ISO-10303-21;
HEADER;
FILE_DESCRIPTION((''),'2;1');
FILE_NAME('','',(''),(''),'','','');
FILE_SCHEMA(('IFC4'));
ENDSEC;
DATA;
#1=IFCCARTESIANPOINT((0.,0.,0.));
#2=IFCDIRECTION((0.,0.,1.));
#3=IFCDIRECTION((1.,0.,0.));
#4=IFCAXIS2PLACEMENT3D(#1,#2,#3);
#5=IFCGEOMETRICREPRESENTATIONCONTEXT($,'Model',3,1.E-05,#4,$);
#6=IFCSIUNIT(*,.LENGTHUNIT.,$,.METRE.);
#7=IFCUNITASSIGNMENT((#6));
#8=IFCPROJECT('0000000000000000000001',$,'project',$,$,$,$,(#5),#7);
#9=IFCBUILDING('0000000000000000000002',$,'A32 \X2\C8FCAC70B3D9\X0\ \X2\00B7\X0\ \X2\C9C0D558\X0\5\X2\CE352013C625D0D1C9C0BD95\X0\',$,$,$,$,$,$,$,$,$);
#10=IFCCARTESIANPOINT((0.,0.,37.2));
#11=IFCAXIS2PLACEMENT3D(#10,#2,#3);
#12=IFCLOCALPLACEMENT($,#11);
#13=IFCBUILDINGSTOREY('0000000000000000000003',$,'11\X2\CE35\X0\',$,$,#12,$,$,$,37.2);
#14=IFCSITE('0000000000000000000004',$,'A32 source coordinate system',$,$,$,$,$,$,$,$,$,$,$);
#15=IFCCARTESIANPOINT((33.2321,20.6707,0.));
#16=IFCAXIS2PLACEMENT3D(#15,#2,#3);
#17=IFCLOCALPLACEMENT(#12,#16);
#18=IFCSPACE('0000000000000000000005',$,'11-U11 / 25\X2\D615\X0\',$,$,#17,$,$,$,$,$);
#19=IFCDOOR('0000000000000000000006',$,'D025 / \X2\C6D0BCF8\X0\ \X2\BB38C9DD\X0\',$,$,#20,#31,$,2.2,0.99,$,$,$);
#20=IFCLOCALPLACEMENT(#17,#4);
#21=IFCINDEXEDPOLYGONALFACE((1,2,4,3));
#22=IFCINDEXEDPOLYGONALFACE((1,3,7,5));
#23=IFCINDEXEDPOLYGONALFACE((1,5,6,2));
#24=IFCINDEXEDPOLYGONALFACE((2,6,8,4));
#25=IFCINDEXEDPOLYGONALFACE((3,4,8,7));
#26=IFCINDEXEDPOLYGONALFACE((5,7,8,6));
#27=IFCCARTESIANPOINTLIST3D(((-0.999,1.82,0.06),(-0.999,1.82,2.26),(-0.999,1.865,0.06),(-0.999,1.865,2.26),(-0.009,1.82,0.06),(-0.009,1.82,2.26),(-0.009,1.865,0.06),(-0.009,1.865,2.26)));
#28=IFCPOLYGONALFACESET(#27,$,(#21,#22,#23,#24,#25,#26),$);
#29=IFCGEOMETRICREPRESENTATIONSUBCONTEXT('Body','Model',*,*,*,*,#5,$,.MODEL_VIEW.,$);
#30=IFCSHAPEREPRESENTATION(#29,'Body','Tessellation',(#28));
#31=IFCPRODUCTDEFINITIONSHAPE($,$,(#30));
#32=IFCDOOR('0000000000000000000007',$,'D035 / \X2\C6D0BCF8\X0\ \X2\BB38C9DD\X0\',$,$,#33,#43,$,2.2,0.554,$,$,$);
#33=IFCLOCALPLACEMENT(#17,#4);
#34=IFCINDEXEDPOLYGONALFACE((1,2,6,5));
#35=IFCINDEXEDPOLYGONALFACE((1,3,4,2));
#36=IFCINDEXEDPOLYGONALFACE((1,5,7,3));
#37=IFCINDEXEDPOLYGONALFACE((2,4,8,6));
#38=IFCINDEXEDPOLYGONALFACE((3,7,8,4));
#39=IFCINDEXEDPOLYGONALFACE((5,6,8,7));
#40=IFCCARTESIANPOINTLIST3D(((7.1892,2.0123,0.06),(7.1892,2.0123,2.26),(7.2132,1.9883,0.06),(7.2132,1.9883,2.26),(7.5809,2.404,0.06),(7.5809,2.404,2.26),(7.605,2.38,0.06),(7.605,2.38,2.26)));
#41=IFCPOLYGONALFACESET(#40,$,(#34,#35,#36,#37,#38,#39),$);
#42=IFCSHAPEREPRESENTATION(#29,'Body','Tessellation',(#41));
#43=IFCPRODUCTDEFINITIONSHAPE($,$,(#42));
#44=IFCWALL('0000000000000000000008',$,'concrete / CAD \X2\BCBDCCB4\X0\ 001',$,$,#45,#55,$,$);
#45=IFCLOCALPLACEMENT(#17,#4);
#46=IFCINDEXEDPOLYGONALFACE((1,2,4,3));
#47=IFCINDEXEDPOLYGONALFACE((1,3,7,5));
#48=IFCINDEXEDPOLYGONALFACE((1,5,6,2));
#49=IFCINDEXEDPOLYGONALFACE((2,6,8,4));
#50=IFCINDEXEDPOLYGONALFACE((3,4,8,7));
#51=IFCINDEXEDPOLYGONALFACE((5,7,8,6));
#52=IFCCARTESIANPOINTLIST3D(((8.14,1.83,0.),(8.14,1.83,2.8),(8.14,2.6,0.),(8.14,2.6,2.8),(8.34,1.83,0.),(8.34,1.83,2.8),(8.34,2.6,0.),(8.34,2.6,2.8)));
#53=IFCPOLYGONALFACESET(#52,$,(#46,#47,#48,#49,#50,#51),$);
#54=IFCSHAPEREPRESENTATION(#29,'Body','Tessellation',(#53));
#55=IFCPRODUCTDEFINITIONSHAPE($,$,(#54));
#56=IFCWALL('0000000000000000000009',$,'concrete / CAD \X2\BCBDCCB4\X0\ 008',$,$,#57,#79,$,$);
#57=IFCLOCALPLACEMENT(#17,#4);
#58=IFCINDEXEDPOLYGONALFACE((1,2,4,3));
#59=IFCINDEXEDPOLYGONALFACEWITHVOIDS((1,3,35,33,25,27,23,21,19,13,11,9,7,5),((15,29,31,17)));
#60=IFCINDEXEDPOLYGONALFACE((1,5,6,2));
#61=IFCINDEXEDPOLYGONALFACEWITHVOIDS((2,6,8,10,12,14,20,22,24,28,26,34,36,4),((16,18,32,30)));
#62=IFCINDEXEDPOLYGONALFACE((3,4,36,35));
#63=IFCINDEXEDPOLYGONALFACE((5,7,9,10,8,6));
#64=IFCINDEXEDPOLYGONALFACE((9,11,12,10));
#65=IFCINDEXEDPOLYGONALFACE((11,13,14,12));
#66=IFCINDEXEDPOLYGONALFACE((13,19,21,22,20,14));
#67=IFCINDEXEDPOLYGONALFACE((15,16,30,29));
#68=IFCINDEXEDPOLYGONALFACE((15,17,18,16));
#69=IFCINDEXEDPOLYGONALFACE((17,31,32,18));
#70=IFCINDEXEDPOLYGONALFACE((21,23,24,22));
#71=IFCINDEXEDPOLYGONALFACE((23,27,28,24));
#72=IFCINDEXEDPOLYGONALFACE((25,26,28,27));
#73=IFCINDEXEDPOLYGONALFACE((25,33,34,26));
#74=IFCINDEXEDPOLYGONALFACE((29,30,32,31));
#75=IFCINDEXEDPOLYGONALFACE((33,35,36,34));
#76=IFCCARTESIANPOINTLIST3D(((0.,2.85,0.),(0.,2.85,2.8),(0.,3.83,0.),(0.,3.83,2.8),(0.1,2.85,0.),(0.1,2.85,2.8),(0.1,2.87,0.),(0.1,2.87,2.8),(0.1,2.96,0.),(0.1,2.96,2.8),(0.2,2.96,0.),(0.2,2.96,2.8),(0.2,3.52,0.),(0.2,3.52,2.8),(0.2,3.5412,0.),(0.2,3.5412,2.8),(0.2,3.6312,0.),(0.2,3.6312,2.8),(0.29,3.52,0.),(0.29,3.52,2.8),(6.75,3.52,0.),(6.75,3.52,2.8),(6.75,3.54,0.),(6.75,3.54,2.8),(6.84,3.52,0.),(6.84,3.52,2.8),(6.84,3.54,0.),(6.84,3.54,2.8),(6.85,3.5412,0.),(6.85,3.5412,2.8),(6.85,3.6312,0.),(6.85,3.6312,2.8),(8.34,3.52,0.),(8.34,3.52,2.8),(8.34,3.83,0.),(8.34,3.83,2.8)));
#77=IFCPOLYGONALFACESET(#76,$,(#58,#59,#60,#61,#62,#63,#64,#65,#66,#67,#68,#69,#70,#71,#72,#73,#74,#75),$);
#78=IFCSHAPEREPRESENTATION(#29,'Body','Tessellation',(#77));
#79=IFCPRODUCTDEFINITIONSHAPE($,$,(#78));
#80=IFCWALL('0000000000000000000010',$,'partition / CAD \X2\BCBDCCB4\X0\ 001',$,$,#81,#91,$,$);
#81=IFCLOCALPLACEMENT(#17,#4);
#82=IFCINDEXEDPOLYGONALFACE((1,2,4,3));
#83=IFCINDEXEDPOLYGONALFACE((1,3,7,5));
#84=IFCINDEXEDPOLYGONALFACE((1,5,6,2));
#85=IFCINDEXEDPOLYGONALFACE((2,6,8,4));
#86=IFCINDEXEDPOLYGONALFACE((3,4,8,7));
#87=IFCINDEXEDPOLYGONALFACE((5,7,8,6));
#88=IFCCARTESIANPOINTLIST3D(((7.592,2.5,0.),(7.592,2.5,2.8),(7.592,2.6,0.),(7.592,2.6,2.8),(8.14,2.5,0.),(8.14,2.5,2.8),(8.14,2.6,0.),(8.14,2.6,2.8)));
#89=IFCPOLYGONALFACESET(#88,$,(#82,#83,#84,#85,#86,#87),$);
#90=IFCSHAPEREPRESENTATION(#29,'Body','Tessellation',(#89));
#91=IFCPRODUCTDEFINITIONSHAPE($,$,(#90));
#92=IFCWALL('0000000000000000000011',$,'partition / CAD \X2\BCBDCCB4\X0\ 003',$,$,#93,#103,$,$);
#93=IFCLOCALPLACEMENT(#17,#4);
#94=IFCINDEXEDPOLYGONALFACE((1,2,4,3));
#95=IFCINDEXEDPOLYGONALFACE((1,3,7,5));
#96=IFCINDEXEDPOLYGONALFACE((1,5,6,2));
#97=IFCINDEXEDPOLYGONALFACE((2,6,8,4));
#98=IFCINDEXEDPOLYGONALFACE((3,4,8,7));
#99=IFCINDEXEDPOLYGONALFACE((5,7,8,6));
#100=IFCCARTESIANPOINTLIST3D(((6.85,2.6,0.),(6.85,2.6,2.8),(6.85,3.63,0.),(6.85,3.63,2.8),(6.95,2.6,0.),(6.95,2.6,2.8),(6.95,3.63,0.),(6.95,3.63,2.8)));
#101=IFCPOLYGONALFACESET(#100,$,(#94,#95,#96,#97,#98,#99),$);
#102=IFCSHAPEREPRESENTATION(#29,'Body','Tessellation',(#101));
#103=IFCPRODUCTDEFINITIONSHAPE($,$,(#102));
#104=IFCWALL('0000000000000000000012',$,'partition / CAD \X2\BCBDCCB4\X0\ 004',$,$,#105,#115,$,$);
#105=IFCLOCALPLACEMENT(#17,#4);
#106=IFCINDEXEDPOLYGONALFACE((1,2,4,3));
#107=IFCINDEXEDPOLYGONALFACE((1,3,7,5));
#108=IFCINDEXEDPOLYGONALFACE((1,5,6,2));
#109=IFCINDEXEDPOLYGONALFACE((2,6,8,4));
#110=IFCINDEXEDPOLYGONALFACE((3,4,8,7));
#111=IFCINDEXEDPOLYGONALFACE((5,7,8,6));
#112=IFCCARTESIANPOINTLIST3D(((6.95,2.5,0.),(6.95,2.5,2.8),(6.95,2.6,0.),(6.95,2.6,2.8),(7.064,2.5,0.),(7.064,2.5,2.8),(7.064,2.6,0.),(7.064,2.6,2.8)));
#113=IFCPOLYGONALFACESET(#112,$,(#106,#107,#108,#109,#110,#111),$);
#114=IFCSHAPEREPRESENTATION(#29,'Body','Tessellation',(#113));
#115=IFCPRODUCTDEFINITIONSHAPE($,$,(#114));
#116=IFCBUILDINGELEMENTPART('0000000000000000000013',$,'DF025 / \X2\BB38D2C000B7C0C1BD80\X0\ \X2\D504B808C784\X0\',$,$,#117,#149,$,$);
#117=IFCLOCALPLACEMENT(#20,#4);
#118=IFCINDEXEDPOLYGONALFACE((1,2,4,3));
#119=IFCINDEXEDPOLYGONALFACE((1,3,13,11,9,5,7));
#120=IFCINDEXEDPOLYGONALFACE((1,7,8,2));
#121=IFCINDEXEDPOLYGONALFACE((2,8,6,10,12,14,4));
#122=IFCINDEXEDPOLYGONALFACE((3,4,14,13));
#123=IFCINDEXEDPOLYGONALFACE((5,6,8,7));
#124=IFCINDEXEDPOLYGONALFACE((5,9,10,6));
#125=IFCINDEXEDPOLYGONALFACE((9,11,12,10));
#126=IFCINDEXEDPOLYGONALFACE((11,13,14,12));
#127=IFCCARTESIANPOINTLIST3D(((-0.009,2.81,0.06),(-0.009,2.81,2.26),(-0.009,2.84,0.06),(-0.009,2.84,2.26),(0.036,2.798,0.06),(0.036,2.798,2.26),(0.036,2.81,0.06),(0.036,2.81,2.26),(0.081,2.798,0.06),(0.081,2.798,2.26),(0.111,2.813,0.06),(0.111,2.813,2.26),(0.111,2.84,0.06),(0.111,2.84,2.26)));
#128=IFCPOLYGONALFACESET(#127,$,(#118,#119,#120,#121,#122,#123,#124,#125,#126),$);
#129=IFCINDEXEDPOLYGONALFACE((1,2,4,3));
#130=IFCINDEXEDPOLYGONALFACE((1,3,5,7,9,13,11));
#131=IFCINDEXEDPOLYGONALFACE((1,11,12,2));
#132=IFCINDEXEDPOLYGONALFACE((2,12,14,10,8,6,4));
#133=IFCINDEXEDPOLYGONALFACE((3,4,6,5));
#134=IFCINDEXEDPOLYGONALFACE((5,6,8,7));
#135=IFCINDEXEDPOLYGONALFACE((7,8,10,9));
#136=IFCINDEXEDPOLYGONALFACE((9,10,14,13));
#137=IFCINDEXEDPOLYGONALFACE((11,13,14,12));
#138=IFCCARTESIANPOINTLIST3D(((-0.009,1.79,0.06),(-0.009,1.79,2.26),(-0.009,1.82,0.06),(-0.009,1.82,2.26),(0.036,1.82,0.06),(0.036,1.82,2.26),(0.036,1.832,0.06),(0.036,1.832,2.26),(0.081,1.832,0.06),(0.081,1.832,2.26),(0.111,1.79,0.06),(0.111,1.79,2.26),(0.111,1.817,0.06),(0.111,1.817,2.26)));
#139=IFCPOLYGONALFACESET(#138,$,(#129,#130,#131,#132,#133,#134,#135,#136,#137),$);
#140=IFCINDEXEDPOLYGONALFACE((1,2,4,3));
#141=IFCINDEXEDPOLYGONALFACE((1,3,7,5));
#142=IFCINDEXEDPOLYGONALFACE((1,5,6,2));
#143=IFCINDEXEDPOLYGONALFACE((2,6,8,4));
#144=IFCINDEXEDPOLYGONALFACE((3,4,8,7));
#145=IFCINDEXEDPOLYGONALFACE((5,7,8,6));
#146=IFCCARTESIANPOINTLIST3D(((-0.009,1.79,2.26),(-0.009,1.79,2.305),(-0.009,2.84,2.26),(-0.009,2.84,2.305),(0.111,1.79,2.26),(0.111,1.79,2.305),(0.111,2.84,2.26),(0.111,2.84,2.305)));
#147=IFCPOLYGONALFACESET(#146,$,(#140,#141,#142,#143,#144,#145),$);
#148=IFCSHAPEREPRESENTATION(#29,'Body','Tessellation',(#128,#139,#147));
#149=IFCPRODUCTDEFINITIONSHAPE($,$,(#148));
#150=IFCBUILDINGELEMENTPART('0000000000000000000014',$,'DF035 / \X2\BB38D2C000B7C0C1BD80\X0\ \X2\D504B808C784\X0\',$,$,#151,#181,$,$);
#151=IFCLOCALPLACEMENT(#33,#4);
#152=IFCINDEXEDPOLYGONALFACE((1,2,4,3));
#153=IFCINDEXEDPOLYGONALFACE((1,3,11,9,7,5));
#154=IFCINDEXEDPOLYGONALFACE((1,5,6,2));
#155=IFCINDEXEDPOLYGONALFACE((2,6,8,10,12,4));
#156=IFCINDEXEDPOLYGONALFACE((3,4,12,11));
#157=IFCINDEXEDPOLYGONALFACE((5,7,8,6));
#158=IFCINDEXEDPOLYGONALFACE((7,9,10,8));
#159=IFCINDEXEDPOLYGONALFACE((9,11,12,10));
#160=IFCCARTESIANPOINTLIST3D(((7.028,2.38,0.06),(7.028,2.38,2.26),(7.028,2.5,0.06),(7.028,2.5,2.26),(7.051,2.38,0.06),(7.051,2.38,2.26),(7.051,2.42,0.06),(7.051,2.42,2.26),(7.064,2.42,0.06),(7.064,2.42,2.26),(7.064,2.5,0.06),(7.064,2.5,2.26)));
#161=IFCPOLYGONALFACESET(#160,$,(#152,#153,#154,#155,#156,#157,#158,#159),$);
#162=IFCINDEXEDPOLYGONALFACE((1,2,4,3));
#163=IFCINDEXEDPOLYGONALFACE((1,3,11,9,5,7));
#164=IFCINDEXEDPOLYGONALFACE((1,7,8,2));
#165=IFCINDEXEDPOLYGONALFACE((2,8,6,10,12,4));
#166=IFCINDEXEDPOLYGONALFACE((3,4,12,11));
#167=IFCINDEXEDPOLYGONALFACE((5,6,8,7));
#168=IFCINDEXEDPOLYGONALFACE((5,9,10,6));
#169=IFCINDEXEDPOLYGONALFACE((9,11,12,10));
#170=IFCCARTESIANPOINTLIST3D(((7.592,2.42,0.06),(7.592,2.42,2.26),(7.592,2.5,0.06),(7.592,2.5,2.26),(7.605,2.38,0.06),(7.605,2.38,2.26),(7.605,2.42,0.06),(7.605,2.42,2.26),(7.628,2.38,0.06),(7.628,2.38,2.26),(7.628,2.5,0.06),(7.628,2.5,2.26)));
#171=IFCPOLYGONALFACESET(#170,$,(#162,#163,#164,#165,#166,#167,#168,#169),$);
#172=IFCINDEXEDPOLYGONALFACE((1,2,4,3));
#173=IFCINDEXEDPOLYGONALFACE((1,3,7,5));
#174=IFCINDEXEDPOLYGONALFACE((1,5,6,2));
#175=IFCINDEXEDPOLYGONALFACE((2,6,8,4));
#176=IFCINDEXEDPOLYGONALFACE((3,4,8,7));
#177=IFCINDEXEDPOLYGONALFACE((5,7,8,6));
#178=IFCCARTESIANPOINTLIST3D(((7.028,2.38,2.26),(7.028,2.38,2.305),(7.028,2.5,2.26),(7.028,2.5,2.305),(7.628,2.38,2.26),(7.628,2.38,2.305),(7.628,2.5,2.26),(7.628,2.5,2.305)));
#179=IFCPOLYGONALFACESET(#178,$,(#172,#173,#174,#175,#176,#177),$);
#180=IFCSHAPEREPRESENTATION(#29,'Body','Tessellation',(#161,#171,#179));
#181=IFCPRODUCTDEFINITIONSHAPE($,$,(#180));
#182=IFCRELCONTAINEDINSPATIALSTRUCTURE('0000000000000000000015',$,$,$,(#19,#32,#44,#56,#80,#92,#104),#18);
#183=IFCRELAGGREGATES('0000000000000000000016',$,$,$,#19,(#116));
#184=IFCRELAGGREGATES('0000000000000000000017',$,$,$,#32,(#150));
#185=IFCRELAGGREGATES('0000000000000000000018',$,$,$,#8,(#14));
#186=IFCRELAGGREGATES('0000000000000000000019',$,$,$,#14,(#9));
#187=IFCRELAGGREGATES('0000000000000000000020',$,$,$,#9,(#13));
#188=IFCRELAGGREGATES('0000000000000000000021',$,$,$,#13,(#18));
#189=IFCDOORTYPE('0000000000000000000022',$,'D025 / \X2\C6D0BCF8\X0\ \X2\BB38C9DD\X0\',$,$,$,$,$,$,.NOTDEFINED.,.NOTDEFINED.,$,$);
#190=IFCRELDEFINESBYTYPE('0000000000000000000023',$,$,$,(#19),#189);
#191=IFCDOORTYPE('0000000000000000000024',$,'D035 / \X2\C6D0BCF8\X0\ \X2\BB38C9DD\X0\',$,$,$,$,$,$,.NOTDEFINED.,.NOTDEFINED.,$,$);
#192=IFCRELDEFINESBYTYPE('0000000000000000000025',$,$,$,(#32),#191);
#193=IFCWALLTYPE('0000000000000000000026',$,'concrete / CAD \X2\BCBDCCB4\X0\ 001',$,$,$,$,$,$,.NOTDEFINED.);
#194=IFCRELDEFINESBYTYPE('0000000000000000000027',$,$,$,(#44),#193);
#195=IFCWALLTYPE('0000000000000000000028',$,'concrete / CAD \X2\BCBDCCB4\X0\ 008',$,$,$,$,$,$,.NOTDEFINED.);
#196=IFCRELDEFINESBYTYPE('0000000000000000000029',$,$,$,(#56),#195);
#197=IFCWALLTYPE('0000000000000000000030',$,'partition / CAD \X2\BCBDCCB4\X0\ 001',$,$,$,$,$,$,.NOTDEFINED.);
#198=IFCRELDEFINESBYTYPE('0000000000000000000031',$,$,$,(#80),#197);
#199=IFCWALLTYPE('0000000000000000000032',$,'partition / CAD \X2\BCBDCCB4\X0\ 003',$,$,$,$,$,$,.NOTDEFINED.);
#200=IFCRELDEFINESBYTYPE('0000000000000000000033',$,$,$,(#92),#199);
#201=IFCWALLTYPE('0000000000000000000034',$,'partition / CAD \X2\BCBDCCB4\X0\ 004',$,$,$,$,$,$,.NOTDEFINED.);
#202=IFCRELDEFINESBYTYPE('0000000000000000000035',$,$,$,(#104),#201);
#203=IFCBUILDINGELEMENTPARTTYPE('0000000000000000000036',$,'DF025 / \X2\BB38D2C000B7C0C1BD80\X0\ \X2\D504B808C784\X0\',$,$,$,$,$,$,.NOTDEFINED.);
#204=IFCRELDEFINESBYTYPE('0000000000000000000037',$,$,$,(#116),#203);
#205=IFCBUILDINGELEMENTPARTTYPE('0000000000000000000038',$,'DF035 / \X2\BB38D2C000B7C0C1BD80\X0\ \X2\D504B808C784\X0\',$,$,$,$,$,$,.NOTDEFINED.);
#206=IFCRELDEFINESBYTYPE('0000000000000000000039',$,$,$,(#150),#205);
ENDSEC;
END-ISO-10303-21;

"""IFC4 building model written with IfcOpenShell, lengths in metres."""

from ifc_helpers import new_model, si_unit, frame, origin, origin_with_axes, place, context, subcontext, project, spatial, polyline, outline, extrude, source, transform, mapped, type_object, type_shapes, element, aggregate, save


model = new_model("IFC4")

# Units and contexts
model_context = context("Model", 3, precision=1e-05, world=origin_with_axes())
body_context = subcontext(model_context, "Body", "Model", "MODEL_VIEW")
ifc_project = project(units=[si_unit("LENGTHUNIT", "METRE")], contexts=[model_context])

# Site, building, storey, space
storey_placement = place(None, frame((0.0, 0.0, 37.2), z_axis=(0.0, 0.0, 1.0), x_axis=(1.0, 0.0, 0.0)))
space_placement = place(storey_placement, frame((33.2321, 20.6707, 0.0), z_axis=(0.0, 0.0, 1.0), x_axis=(1.0, 0.0, 0.0)))
site = spatial("IfcSite", under=ifc_project, Name="A32 source coordinate system")
building = spatial("IfcBuilding", under=site, Name="A32 주거동 · 지하5층–옥탑지붕")
storey = spatial("IfcBuildingStorey", under=building, at=storey_placement, Name="11층", Elevation=37.2)
space = spatial("IfcSpace", under=storey, at=space_placement, Name="11-U11 / 25형")

# Doors
door_type_1 = type_object("IfcDoorType", Name="D025 / 원본 문짝", OperationType="NOTDEFINED", PredefinedType="NOTDEFINED")
shared_shape_1 = source(origin(), body_context, "Body", "SweptSolid", [
    extrude(outline(polyline([(-0.009, 1.82), (-0.999, 1.82), (-0.999, 1.865), (-0.009, 1.865), (-0.009, 1.82)])), frame((0.0, 0.0, 0.06)), (0.0, 0.0, 1.0), 2.2),
])
type_shapes(door_type_1, [shared_shape_1])
door_1_placement = place(space_placement, origin_with_axes())
door_1 = element("IfcDoor", 1, at=door_1_placement, inside=space, type_object=door_type_1, Name="D025 / 원본 문짝", OverallHeight=2.2, OverallWidth=0.99, context=body_context, shape_type="MappedRepresentation", body=[
    mapped(shared_shape_1, transform((0.0, 0.0, 0.0), scale=1.0)),
])
door_type_2 = type_object("IfcDoorType", Name="D035 / 원본 문짝", OperationType="NOTDEFINED", PredefinedType="NOTDEFINED")
shared_shape_2 = source(origin(), body_context, "Body", "SweptSolid", [
    extrude(outline(polyline([(7.605, 2.38), (7.2132, 1.9883), (7.1892, 2.0123), (7.5809, 2.404), (7.605, 2.38)])), frame((0.0, 0.0, 0.06)), (0.0, 0.0, 1.0), 2.2),
])
type_shapes(door_type_2, [shared_shape_2])
door_2_placement = place(space_placement, origin_with_axes())
door_2 = element("IfcDoor", 2, at=door_2_placement, inside=space, type_object=door_type_2, Name="D035 / 원본 문짝", OverallHeight=2.2, OverallWidth=0.554, context=body_context, shape_type="MappedRepresentation", body=[
    mapped(shared_shape_2, transform((0.0, 0.0, 0.0), scale=1.0)),
])

# Walls
wall_type_1 = type_object("IfcWallType", Name="concrete / CAD 벽체 001", PredefinedType="NOTDEFINED")
shared_shape_3 = source(origin(), body_context, "Body", "SweptSolid", [
    extrude(outline(polyline([(8.34, 1.83), (8.14, 1.83), (8.14, 2.6), (8.34, 2.6), (8.34, 1.83)])), origin(), (0.0, 0.0, 1.0), 2.8),
])
type_shapes(wall_type_1, [shared_shape_3])
wall_1_placement = place(space_placement, origin_with_axes())
element("IfcWall", 3, at=wall_1_placement, inside=space, type_object=wall_type_1, Name="concrete / CAD 벽체 001", context=body_context, shape_type="MappedRepresentation", body=[
    mapped(shared_shape_3, transform((0.0, 0.0, 0.0), scale=1.0)),
])
wall_type_2 = type_object("IfcWallType", Name="concrete / CAD 벽체 008", PredefinedType="NOTDEFINED")
shared_shape_4 = source(origin(), body_context, "Body", "SweptSolid", [
    extrude(outline(polyline([(0.0, 3.83), (8.34, 3.83), (8.34, 3.52), (6.84, 3.52), (6.84, 3.54), (6.75, 3.54), (6.75, 3.52), (0.29, 3.52), (0.2, 3.52), (0.2, 2.96), (0.1, 2.96), (0.1, 2.87), (0.1, 2.85), (0.0, 2.85), (0.0, 3.83)]), holes=[polyline([(6.85, 3.5412), (6.85, 3.6312), (0.2, 3.6312), (0.2, 3.5412), (6.85, 3.5412)])]), origin(), (0.0, 0.0, 1.0), 2.8),
])
type_shapes(wall_type_2, [shared_shape_4])
wall_2_placement = place(space_placement, origin_with_axes())
element("IfcWall", 4, at=wall_2_placement, inside=space, type_object=wall_type_2, Name="concrete / CAD 벽체 008", context=body_context, shape_type="MappedRepresentation", body=[
    mapped(shared_shape_4, transform((0.0, 0.0, 0.0), scale=1.0)),
])
wall_type_3 = type_object("IfcWallType", Name="partition / CAD 벽체 001", PredefinedType="NOTDEFINED")
shared_shape_5 = source(origin(), body_context, "Body", "SweptSolid", [
    extrude(outline(polyline([(8.14, 2.6), (8.14, 2.5), (7.592, 2.5), (7.592, 2.6), (8.14, 2.6)])), origin(), (0.0, 0.0, 1.0), 2.8),
])
type_shapes(wall_type_3, [shared_shape_5])
wall_3_placement = place(space_placement, origin_with_axes())
element("IfcWall", 5, at=wall_3_placement, inside=space, type_object=wall_type_3, Name="partition / CAD 벽체 001", context=body_context, shape_type="MappedRepresentation", body=[
    mapped(shared_shape_5, transform((0.0, 0.0, 0.0), scale=1.0)),
])
wall_type_4 = type_object("IfcWallType", Name="partition / CAD 벽체 003", PredefinedType="NOTDEFINED")
shared_shape_6 = source(origin(), body_context, "Body", "SweptSolid", [
    extrude(outline(polyline([(6.85, 2.6), (6.85, 3.63), (6.95, 3.63), (6.95, 2.6), (6.85, 2.6)])), origin(), (0.0, 0.0, 1.0), 2.8),
])
type_shapes(wall_type_4, [shared_shape_6])
wall_4_placement = place(space_placement, origin_with_axes())
element("IfcWall", 6, at=wall_4_placement, inside=space, type_object=wall_type_4, Name="partition / CAD 벽체 003", context=body_context, shape_type="MappedRepresentation", body=[
    mapped(shared_shape_6, transform((0.0, 0.0, 0.0), scale=1.0)),
])
wall_type_5 = type_object("IfcWallType", Name="partition / CAD 벽체 004", PredefinedType="NOTDEFINED")
shared_shape_7 = source(origin(), body_context, "Body", "SweptSolid", [
    extrude(outline(polyline([(6.95, 2.5), (6.95, 2.6), (7.064, 2.6), (7.064, 2.5), (6.95, 2.5)])), origin(), (0.0, 0.0, 1.0), 2.8),
])
type_shapes(wall_type_5, [shared_shape_7])
wall_5_placement = place(space_placement, origin_with_axes())
element("IfcWall", 7, at=wall_5_placement, inside=space, type_object=wall_type_5, Name="partition / CAD 벽체 004", context=body_context, shape_type="MappedRepresentation", body=[
    mapped(shared_shape_7, transform((0.0, 0.0, 0.0), scale=1.0)),
])

# Building element parts
building_element_part_type_1 = type_object("IfcBuildingElementPartType", Name="DF025 / 문틀·상부 프레임", PredefinedType="NOTDEFINED")
shared_shape_8 = source(origin(), body_context, "Body", "SweptSolid", [
    extrude(outline(polyline([(0.111, 2.84), (0.111, 2.813), (0.081, 2.798), (0.036, 2.798), (0.036, 2.81), (-0.009, 2.81), (-0.009, 2.84), (0.111, 2.84)])), frame((0.0, 0.0, 0.06)), (0.0, 0.0, 1.0), 2.2),
    extrude(outline(polyline([(-0.009, 1.82), (0.036, 1.82), (0.036, 1.832), (0.081, 1.832), (0.111, 1.817), (0.111, 1.79), (-0.009, 1.79), (-0.009, 1.82)])), frame((0.0, 0.0, 0.06)), (0.0, 0.0, 1.0), 2.2),
    extrude(outline(polyline([(-0.009, 1.79), (-0.009, 2.84), (0.111, 2.84), (0.111, 1.79), (-0.009, 1.79)])), frame((0.0, 0.0, 2.26)), (0.0, 0.0, 1.0), 0.045),
])
type_shapes(building_element_part_type_1, [shared_shape_8])
building_element_part_1_placement = place(door_1_placement, origin_with_axes())
building_element_part_1 = element("IfcBuildingElementPart", 8, at=building_element_part_1_placement, type_object=building_element_part_type_1, Name="DF025 / 문틀·상부 프레임", context=body_context, shape_type="MappedRepresentation", body=[
    mapped(shared_shape_8, transform((0.0, 0.0, 0.0), scale=1.0)),
])
aggregate(door_1, [building_element_part_1])
building_element_part_type_2 = type_object("IfcBuildingElementPartType", Name="DF035 / 문틀·상부 프레임", PredefinedType="NOTDEFINED")
shared_shape_9 = source(origin(), body_context, "Body", "SweptSolid", [
    extrude(outline(polyline([(7.064, 2.5), (7.064, 2.42), (7.051, 2.42), (7.051, 2.38), (7.028, 2.38), (7.028, 2.5), (7.064, 2.5)])), frame((0.0, 0.0, 0.06)), (0.0, 0.0, 1.0), 2.2),
    extrude(outline(polyline([(7.628, 2.38), (7.605, 2.38), (7.605, 2.42), (7.592, 2.42), (7.592, 2.5), (7.628, 2.5), (7.628, 2.38)])), frame((0.0, 0.0, 0.06)), (0.0, 0.0, 1.0), 2.2),
    extrude(outline(polyline([(7.028, 2.38), (7.028, 2.5), (7.628, 2.5), (7.628, 2.38), (7.028, 2.38)])), frame((0.0, 0.0, 2.26)), (0.0, 0.0, 1.0), 0.045),
])
type_shapes(building_element_part_type_2, [shared_shape_9])
building_element_part_2_placement = place(door_2_placement, origin_with_axes())
building_element_part_2 = element("IfcBuildingElementPart", 9, at=building_element_part_2_placement, type_object=building_element_part_type_2, Name="DF035 / 문틀·상부 프레임", context=body_context, shape_type="MappedRepresentation", body=[
    mapped(shared_shape_9, transform((0.0, 0.0, 0.0), scale=1.0)),
])
aggregate(door_2, [building_element_part_2])

save(model, "model.ifc")
